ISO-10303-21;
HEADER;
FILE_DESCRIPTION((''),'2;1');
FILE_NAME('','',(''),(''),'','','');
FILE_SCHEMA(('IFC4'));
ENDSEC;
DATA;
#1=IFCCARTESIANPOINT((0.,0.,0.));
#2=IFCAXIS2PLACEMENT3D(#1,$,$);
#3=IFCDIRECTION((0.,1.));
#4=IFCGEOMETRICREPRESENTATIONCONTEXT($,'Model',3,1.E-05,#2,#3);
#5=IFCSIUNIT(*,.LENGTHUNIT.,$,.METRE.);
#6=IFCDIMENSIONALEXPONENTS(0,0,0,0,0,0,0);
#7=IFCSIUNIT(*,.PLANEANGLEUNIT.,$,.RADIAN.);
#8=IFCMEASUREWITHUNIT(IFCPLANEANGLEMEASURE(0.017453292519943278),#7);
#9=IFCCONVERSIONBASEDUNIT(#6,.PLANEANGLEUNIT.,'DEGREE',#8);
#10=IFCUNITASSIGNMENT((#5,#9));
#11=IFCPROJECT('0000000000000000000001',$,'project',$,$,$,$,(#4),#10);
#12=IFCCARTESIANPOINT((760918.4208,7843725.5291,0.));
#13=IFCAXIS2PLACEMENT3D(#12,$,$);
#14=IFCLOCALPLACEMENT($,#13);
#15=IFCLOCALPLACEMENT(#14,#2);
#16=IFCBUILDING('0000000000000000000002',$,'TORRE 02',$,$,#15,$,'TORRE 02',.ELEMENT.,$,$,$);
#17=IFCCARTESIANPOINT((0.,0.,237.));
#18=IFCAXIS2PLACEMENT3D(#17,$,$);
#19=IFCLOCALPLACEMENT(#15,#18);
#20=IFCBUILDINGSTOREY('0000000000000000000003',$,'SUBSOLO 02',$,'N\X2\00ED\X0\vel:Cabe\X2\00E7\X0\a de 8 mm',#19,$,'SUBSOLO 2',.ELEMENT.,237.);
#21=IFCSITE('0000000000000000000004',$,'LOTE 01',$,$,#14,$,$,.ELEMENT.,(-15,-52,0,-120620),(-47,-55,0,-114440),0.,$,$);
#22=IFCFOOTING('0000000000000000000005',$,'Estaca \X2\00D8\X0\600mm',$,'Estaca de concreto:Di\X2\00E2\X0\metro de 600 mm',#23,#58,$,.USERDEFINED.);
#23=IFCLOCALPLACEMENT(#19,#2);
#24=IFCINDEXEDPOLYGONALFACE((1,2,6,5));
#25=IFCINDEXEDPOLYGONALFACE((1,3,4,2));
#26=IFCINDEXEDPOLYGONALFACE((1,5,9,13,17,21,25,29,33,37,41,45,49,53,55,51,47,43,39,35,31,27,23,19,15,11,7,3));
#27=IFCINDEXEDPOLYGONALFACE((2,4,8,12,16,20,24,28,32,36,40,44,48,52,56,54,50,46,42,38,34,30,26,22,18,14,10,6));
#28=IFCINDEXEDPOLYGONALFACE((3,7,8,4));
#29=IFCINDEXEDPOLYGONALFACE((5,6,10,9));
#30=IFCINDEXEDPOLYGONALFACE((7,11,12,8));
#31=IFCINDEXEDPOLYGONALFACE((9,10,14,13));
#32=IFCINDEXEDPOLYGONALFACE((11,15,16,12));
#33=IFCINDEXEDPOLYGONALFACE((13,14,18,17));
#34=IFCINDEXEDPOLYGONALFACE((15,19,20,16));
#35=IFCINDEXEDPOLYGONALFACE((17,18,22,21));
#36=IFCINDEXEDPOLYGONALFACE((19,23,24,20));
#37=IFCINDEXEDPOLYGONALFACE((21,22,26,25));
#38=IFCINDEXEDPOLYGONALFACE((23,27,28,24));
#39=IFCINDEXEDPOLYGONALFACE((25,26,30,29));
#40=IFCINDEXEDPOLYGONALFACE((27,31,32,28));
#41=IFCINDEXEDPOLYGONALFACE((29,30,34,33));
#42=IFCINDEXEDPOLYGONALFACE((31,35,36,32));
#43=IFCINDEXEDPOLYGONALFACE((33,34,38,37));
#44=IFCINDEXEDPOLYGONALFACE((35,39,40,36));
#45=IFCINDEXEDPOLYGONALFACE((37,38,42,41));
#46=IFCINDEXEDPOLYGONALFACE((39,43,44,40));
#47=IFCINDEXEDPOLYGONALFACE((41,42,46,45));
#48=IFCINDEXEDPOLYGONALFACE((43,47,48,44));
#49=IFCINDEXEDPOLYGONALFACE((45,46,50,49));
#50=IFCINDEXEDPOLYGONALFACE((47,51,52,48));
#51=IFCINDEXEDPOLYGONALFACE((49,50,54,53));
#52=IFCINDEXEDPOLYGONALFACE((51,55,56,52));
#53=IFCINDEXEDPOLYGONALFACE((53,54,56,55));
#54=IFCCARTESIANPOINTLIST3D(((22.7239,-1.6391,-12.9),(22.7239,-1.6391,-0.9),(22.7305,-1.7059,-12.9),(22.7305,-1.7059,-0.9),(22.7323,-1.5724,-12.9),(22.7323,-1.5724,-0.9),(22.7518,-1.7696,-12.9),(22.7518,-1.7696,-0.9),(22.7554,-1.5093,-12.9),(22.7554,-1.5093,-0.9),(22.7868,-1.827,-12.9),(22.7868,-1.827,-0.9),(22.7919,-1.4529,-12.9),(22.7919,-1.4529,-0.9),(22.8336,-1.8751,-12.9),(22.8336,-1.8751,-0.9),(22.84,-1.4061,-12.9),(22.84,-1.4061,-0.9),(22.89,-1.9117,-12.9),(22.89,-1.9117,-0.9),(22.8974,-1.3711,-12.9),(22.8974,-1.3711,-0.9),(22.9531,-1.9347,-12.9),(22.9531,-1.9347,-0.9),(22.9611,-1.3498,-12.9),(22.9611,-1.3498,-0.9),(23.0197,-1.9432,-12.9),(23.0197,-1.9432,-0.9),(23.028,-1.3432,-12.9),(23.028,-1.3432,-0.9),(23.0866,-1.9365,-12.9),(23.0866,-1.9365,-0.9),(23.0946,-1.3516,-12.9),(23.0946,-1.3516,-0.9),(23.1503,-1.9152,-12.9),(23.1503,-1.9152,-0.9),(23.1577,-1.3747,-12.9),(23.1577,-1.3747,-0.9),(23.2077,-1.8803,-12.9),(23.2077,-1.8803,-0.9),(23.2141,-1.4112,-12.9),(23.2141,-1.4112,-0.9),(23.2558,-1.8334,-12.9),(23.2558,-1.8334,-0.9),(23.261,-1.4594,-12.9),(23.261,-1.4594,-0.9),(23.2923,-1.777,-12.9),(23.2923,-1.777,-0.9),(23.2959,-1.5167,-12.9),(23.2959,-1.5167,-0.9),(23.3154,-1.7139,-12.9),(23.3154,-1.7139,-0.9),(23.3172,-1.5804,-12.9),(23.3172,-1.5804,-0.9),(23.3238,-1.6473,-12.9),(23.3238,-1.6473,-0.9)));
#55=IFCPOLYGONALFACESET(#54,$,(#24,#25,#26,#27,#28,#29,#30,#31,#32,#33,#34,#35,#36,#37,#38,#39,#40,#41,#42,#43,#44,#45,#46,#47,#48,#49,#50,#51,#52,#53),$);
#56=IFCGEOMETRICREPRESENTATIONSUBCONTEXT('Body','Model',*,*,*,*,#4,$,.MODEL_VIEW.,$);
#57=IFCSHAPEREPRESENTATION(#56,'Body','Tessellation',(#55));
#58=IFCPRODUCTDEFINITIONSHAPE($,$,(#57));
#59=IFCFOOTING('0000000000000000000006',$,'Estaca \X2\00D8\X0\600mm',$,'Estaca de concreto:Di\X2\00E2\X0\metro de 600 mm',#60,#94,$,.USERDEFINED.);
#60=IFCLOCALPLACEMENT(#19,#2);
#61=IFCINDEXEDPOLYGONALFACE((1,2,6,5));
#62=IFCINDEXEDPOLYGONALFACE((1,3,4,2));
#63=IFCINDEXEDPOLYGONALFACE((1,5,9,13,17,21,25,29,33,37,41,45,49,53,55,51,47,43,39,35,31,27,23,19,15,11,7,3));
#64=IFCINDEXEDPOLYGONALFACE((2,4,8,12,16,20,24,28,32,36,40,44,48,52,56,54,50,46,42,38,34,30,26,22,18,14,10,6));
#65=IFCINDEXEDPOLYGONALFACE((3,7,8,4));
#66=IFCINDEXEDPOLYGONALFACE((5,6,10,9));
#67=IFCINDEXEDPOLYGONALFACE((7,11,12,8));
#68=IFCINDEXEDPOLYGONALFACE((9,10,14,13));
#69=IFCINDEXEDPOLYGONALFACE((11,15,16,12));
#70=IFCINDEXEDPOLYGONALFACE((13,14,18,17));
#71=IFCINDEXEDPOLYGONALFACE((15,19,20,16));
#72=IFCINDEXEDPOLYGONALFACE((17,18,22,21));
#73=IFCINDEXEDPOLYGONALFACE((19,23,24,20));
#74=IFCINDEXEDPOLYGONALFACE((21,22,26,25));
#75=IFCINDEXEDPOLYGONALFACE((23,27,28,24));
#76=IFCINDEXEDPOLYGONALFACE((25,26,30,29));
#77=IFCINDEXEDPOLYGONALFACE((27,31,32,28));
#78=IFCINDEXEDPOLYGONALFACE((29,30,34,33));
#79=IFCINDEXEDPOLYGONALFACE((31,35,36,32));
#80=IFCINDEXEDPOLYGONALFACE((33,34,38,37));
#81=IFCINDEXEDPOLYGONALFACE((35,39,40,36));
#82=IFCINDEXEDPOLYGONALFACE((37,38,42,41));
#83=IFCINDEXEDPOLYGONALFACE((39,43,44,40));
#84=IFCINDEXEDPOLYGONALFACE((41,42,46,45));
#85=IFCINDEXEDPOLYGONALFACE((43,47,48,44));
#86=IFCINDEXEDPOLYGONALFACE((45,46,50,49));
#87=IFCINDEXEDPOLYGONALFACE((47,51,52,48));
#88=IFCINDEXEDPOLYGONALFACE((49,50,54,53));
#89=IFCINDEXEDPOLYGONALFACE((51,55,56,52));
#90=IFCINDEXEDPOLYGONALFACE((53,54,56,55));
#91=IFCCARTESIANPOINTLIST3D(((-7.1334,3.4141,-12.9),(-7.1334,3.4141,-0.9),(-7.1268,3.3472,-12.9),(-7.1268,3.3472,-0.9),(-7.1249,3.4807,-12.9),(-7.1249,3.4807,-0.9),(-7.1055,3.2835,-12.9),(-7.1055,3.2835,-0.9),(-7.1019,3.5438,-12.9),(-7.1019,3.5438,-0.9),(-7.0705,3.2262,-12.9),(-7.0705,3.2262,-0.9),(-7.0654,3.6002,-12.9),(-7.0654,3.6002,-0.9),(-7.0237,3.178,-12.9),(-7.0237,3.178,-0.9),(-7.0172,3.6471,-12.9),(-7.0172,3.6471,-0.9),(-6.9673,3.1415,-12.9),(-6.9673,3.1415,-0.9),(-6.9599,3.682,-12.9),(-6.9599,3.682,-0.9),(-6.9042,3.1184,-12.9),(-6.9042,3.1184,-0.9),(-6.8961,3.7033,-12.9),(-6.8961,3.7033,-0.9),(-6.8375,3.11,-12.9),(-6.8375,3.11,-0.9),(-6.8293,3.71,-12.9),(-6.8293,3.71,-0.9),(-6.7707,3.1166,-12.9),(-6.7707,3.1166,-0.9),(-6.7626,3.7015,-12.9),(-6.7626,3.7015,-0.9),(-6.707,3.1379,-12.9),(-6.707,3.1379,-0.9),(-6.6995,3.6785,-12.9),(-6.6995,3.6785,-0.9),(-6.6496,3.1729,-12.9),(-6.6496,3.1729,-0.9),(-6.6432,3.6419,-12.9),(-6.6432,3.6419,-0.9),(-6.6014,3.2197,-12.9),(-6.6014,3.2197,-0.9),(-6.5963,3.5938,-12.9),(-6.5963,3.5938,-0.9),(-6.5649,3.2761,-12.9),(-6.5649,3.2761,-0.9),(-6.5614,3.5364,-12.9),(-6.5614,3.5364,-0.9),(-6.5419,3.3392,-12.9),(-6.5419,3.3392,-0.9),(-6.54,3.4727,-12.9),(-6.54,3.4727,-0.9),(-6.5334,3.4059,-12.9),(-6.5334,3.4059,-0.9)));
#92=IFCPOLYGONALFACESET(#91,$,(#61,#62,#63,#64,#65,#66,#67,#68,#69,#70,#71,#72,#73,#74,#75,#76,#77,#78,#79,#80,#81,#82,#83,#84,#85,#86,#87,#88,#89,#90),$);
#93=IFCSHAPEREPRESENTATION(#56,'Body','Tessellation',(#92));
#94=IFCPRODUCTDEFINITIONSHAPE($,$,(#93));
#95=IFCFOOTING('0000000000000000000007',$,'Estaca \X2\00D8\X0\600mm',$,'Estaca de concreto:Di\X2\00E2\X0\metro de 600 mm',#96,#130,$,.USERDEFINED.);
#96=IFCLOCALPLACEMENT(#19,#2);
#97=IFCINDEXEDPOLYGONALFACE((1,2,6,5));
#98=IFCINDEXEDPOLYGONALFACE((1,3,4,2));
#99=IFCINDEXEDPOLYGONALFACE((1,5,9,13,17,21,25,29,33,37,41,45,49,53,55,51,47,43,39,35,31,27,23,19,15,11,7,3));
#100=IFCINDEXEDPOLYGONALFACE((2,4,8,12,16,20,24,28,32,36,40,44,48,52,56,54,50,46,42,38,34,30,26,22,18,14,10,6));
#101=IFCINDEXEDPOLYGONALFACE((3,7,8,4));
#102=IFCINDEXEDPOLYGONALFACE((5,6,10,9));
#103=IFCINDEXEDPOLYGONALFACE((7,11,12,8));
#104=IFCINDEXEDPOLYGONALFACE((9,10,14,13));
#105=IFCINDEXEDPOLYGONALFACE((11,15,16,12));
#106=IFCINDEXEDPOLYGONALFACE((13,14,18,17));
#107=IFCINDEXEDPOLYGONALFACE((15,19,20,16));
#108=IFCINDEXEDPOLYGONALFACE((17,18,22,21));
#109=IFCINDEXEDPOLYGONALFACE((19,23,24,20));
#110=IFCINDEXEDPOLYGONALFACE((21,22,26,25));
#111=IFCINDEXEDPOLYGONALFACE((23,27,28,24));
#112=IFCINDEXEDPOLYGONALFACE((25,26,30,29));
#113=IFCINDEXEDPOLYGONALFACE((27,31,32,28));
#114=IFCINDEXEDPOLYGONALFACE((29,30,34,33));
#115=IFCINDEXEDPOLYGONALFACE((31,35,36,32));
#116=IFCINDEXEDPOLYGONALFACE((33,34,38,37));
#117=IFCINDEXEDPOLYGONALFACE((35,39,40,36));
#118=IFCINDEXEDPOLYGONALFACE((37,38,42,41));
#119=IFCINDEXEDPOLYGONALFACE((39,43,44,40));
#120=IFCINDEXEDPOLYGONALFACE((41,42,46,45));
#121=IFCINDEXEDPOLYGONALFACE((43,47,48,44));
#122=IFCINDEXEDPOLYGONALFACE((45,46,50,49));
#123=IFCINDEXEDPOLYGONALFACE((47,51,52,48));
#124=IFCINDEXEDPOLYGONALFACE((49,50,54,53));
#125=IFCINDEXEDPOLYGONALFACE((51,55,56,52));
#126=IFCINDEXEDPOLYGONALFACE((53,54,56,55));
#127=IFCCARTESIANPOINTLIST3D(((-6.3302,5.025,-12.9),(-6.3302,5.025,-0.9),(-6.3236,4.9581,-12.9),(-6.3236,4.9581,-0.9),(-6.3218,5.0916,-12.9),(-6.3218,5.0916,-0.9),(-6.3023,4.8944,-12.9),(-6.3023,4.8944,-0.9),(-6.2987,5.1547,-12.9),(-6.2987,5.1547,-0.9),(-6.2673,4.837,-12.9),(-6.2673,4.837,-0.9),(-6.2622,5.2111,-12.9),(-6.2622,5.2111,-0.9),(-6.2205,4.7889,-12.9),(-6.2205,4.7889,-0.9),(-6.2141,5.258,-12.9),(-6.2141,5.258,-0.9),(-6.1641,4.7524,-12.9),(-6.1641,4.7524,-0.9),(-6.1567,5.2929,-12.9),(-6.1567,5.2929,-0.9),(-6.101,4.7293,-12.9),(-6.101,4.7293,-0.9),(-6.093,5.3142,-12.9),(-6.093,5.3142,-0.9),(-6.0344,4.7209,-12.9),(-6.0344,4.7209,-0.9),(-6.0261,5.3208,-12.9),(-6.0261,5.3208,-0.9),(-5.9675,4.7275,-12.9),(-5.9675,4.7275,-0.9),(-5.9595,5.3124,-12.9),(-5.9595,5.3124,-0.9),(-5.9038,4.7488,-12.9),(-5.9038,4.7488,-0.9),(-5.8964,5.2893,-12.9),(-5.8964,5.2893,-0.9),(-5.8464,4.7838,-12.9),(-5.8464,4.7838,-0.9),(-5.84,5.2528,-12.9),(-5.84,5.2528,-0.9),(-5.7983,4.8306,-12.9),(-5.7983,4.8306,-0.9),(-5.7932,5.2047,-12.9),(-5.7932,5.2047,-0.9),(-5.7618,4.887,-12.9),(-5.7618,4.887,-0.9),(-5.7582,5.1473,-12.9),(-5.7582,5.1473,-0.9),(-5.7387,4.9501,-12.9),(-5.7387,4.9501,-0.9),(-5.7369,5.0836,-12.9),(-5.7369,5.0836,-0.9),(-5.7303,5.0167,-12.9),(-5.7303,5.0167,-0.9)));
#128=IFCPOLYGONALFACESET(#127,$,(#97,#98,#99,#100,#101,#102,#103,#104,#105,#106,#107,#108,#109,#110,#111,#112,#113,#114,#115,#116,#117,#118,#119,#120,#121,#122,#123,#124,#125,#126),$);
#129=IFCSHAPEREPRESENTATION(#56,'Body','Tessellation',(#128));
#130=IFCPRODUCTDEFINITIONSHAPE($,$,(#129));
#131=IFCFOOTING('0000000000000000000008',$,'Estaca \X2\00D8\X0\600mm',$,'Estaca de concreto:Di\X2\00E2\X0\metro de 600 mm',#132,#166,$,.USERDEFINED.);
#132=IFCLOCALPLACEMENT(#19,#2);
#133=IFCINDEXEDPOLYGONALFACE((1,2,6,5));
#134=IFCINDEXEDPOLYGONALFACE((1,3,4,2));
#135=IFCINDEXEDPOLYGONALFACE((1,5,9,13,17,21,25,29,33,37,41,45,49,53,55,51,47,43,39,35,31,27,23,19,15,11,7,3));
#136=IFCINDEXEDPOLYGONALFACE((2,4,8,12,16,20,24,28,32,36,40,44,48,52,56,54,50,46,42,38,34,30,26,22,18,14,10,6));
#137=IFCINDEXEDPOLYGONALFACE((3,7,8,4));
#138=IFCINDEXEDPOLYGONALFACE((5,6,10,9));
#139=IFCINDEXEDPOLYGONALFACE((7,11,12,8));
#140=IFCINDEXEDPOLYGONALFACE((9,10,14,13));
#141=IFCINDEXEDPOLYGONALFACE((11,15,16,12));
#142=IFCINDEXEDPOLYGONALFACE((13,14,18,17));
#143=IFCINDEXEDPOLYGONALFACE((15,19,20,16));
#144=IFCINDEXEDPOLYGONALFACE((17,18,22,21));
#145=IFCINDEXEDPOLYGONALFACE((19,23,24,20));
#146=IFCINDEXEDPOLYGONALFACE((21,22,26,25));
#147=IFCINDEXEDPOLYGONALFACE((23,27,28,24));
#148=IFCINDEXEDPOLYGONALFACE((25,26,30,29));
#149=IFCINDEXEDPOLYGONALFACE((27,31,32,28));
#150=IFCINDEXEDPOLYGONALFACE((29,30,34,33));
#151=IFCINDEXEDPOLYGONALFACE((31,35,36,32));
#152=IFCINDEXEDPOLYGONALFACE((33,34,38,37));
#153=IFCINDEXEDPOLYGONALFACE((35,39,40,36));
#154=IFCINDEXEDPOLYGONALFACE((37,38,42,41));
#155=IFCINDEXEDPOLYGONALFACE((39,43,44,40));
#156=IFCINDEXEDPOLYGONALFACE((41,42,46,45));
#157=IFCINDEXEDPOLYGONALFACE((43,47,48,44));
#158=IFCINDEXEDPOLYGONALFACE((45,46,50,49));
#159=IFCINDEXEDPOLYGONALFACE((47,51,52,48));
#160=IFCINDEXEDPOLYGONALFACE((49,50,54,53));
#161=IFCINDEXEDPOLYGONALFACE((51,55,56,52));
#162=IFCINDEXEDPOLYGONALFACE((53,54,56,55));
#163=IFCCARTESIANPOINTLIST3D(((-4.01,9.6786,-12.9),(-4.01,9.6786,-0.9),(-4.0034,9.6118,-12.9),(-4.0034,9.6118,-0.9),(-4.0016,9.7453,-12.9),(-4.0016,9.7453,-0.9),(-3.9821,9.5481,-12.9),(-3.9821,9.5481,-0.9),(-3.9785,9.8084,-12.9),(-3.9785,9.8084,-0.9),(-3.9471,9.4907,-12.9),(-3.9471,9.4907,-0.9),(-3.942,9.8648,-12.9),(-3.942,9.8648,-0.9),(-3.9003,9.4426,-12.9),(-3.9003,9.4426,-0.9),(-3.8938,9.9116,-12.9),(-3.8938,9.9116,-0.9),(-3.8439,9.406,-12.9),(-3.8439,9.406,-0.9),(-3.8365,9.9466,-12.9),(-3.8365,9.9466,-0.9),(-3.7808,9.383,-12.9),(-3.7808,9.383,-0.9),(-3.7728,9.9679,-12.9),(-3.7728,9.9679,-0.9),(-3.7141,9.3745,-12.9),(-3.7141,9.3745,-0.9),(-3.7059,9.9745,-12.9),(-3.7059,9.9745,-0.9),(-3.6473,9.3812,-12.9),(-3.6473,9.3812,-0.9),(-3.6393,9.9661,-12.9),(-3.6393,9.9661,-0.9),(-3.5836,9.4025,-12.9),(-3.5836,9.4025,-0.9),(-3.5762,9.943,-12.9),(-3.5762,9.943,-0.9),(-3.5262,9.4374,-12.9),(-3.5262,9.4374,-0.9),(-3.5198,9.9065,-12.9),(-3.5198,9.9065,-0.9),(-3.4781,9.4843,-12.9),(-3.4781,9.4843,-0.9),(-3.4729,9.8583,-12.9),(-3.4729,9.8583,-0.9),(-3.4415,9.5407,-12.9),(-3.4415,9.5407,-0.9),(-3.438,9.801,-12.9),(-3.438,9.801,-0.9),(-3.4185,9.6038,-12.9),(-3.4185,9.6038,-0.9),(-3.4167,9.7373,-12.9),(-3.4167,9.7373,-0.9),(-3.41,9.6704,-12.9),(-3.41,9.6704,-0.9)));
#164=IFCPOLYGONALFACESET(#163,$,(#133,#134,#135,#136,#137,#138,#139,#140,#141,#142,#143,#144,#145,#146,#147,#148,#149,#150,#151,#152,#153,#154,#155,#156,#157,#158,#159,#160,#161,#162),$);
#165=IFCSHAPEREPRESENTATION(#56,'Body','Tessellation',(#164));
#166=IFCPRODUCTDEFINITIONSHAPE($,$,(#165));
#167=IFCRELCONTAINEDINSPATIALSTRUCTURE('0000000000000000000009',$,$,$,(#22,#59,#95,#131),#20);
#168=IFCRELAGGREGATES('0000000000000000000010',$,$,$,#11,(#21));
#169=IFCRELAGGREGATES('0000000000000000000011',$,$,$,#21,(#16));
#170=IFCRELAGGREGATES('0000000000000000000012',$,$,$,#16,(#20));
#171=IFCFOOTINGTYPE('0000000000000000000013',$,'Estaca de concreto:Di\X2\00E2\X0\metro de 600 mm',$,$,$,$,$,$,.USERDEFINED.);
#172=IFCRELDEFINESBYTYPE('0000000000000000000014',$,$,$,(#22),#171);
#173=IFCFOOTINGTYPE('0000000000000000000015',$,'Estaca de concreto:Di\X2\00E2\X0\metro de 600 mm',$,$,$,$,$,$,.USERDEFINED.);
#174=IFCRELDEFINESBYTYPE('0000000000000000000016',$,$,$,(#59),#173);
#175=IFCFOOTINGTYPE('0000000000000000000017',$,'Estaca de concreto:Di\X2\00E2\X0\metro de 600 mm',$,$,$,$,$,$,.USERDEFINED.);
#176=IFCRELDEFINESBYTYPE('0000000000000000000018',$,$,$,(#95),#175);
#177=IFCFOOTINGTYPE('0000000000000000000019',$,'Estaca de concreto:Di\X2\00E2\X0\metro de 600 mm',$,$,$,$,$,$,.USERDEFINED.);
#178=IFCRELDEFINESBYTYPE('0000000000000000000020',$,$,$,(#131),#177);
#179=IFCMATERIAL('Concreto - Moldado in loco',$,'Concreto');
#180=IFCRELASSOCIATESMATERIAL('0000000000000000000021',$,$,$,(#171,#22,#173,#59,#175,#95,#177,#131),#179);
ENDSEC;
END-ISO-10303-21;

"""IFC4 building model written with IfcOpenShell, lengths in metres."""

from ifc_helpers import new_model, entity, si_unit, converted_unit, direction, frame, origin, place, context, subcontext, project, spatial, arc, indexed_curve, outline, extrude, source, transform, mapped, material, type_object, type_shapes, element, save


model = new_model("IFC4")

# Units and contexts
model_context = context("Model", 3, precision=1e-05, world=origin(), true_north=direction((0.0, 1.0)))
body_context = subcontext(model_context, "Body", "Model", "MODEL_VIEW")
ifc_project = project(units=[si_unit("LENGTHUNIT", "METRE"), converted_unit("PLANEANGLEUNIT", "DEGREE", entity("IfcPlaneAngleMeasure", 0.017453292519943278), si_unit("PLANEANGLEUNIT", "RADIAN"), dimensions=[0, 0, 0, 0, 0, 0, 0])], contexts=[model_context])

# Site, building, storey
site_placement = place(None, frame((760918.4208, 7843725.5291, 0.0)))
site = spatial("IfcSite", under=ifc_project, at=site_placement, Name="LOTE 01", CompositionType="ELEMENT", RefLatitude=(-15, -52, 0, -120620), RefLongitude=(-47, -55, 0, -114440), RefElevation=0.0)
building_placement = place(site_placement, origin())
building = spatial("IfcBuilding", under=site, at=building_placement, Name="TORRE 02", LongName="TORRE 02", CompositionType="ELEMENT")
storey_placement = place(building_placement, frame((0.0, 0.0, 237.0)))
storey = spatial("IfcBuildingStorey", under=building, at=storey_placement, Name="SUBSOLO 02", ObjectType="Nível:Cabeça de 8 mm", LongName="SUBSOLO 2", CompositionType="ELEMENT", Elevation=237.0)

# Footings
ifc_material_1 = material(Name="Concreto - Moldado in loco", Category="Concreto")
placement = place(building_placement, frame((0.0, 0.0, 237.0)))
footing_type_1 = type_object("IfcFootingType", Name="Estaca de concreto:Diâmetro de 600 mm", PredefinedType="USERDEFINED", material=ifc_material_1)
shared_shape_1 = source(origin(), body_context, "Body", "SweptSolid", [
    extrude(outline(indexed_curve([(-0.3, 0.0), (0.0, -0.3), (0.3, 0.0), (0.0, 0.3)], segments=[arc(1, 2, 3), arc(3, 4, 1)], self_intersect=False)), frame((23.0239, -1.6432, -12.0), z_axis=(0.0, 0.0, 1.0), x_axis=(0.894934, -0.446198, 0.0)), (0.0, 0.0, 1.0), 12.0),
])
type_shapes(footing_type_1, [shared_shape_1])
footing_1_placement = place(placement, frame((0.0, 0.0, -0.9)))
element("IfcFooting", 1, at=footing_1_placement, inside=storey, type_object=footing_type_1, material=ifc_material_1, Name="Estaca Ø600mm", ObjectType="Estaca de concreto:Diâmetro de 600 mm", PredefinedType="USERDEFINED", context=body_context, shape_type="MappedRepresentation", body=[
    mapped(shared_shape_1, transform((0.0, 0.0, 0.0), scale=1.0)),
])
footing_type_2 = type_object("IfcFootingType", Name="Estaca de concreto:Diâmetro de 600 mm", PredefinedType="USERDEFINED", material=ifc_material_1)
shared_shape_2 = source(origin(), body_context, "Body", "SweptSolid", [
    extrude(outline(indexed_curve([(-0.3, 0.0), (0.0, -0.3), (0.3, 0.0), (0.0, 0.3)], segments=[arc(1, 2, 3), arc(3, 4, 1)], self_intersect=False)), frame((-6.8334, 3.41, -12.0), z_axis=(0.0, 0.0, 1.0), x_axis=(0.446198, 0.894934, 0.0)), (0.0, 0.0, 1.0), 12.0),
])
type_shapes(footing_type_2, [shared_shape_2])
footing_2_placement = place(placement, frame((0.0, 0.0, -0.9)))
element("IfcFooting", 2, at=footing_2_placement, inside=storey, type_object=footing_type_2, material=ifc_material_1, Name="Estaca Ø600mm", ObjectType="Estaca de concreto:Diâmetro de 600 mm", PredefinedType="USERDEFINED", context=body_context, shape_type="MappedRepresentation", body=[
    mapped(shared_shape_2, transform((0.0, 0.0, 0.0), scale=1.0)),
])
footing_type_3 = type_object("IfcFootingType", Name="Estaca de concreto:Diâmetro de 600 mm", PredefinedType="USERDEFINED", material=ifc_material_1)
shared_shape_3 = source(origin(), body_context, "Body", "SweptSolid", [
    extrude(outline(indexed_curve([(-0.3, 0.0), (0.0, -0.3), (0.3, 0.0), (0.0, 0.3)], segments=[arc(1, 2, 3), arc(3, 4, 1)], self_intersect=False)), frame((-6.0302, 5.0209, -12.0), z_axis=(0.0, 0.0, 1.0), x_axis=(0.446198, 0.894934, 0.0)), (0.0, 0.0, 1.0), 12.0),
])
type_shapes(footing_type_3, [shared_shape_3])
footing_3_placement = place(placement, frame((0.0, 0.0, -0.9)))
element("IfcFooting", 3, at=footing_3_placement, inside=storey, type_object=footing_type_3, material=ifc_material_1, Name="Estaca Ø600mm", ObjectType="Estaca de concreto:Diâmetro de 600 mm", PredefinedType="USERDEFINED", context=body_context, shape_type="MappedRepresentation", body=[
    mapped(shared_shape_3, transform((0.0, 0.0, 0.0), scale=1.0)),
])
footing_type_4 = type_object("IfcFootingType", Name="Estaca de concreto:Diâmetro de 600 mm", PredefinedType="USERDEFINED", material=ifc_material_1)
shared_shape_4 = source(origin(), body_context, "Body", "SweptSolid", [
    extrude(outline(indexed_curve([(-0.3, 0.0), (0.0, -0.3), (0.3, 0.0), (0.0, 0.3)], segments=[arc(1, 2, 3), arc(3, 4, 1)], self_intersect=False)), frame((-3.71, 9.6745, -12.0), z_axis=(0.0, 0.0, 1.0), x_axis=(0.446198, 0.894934, 0.0)), (0.0, 0.0, 1.0), 12.0),
])
type_shapes(footing_type_4, [shared_shape_4])
footing_4_placement = place(placement, frame((0.0, 0.0, -0.9)))
element("IfcFooting", 4, at=footing_4_placement, inside=storey, type_object=footing_type_4, material=ifc_material_1, Name="Estaca Ø600mm", ObjectType="Estaca de concreto:Diâmetro de 600 mm", PredefinedType="USERDEFINED", context=body_context, shape_type="MappedRepresentation", body=[
    mapped(shared_shape_4, transform((0.0, 0.0, 0.0), scale=1.0)),
])

save(model, "model.ifc")
